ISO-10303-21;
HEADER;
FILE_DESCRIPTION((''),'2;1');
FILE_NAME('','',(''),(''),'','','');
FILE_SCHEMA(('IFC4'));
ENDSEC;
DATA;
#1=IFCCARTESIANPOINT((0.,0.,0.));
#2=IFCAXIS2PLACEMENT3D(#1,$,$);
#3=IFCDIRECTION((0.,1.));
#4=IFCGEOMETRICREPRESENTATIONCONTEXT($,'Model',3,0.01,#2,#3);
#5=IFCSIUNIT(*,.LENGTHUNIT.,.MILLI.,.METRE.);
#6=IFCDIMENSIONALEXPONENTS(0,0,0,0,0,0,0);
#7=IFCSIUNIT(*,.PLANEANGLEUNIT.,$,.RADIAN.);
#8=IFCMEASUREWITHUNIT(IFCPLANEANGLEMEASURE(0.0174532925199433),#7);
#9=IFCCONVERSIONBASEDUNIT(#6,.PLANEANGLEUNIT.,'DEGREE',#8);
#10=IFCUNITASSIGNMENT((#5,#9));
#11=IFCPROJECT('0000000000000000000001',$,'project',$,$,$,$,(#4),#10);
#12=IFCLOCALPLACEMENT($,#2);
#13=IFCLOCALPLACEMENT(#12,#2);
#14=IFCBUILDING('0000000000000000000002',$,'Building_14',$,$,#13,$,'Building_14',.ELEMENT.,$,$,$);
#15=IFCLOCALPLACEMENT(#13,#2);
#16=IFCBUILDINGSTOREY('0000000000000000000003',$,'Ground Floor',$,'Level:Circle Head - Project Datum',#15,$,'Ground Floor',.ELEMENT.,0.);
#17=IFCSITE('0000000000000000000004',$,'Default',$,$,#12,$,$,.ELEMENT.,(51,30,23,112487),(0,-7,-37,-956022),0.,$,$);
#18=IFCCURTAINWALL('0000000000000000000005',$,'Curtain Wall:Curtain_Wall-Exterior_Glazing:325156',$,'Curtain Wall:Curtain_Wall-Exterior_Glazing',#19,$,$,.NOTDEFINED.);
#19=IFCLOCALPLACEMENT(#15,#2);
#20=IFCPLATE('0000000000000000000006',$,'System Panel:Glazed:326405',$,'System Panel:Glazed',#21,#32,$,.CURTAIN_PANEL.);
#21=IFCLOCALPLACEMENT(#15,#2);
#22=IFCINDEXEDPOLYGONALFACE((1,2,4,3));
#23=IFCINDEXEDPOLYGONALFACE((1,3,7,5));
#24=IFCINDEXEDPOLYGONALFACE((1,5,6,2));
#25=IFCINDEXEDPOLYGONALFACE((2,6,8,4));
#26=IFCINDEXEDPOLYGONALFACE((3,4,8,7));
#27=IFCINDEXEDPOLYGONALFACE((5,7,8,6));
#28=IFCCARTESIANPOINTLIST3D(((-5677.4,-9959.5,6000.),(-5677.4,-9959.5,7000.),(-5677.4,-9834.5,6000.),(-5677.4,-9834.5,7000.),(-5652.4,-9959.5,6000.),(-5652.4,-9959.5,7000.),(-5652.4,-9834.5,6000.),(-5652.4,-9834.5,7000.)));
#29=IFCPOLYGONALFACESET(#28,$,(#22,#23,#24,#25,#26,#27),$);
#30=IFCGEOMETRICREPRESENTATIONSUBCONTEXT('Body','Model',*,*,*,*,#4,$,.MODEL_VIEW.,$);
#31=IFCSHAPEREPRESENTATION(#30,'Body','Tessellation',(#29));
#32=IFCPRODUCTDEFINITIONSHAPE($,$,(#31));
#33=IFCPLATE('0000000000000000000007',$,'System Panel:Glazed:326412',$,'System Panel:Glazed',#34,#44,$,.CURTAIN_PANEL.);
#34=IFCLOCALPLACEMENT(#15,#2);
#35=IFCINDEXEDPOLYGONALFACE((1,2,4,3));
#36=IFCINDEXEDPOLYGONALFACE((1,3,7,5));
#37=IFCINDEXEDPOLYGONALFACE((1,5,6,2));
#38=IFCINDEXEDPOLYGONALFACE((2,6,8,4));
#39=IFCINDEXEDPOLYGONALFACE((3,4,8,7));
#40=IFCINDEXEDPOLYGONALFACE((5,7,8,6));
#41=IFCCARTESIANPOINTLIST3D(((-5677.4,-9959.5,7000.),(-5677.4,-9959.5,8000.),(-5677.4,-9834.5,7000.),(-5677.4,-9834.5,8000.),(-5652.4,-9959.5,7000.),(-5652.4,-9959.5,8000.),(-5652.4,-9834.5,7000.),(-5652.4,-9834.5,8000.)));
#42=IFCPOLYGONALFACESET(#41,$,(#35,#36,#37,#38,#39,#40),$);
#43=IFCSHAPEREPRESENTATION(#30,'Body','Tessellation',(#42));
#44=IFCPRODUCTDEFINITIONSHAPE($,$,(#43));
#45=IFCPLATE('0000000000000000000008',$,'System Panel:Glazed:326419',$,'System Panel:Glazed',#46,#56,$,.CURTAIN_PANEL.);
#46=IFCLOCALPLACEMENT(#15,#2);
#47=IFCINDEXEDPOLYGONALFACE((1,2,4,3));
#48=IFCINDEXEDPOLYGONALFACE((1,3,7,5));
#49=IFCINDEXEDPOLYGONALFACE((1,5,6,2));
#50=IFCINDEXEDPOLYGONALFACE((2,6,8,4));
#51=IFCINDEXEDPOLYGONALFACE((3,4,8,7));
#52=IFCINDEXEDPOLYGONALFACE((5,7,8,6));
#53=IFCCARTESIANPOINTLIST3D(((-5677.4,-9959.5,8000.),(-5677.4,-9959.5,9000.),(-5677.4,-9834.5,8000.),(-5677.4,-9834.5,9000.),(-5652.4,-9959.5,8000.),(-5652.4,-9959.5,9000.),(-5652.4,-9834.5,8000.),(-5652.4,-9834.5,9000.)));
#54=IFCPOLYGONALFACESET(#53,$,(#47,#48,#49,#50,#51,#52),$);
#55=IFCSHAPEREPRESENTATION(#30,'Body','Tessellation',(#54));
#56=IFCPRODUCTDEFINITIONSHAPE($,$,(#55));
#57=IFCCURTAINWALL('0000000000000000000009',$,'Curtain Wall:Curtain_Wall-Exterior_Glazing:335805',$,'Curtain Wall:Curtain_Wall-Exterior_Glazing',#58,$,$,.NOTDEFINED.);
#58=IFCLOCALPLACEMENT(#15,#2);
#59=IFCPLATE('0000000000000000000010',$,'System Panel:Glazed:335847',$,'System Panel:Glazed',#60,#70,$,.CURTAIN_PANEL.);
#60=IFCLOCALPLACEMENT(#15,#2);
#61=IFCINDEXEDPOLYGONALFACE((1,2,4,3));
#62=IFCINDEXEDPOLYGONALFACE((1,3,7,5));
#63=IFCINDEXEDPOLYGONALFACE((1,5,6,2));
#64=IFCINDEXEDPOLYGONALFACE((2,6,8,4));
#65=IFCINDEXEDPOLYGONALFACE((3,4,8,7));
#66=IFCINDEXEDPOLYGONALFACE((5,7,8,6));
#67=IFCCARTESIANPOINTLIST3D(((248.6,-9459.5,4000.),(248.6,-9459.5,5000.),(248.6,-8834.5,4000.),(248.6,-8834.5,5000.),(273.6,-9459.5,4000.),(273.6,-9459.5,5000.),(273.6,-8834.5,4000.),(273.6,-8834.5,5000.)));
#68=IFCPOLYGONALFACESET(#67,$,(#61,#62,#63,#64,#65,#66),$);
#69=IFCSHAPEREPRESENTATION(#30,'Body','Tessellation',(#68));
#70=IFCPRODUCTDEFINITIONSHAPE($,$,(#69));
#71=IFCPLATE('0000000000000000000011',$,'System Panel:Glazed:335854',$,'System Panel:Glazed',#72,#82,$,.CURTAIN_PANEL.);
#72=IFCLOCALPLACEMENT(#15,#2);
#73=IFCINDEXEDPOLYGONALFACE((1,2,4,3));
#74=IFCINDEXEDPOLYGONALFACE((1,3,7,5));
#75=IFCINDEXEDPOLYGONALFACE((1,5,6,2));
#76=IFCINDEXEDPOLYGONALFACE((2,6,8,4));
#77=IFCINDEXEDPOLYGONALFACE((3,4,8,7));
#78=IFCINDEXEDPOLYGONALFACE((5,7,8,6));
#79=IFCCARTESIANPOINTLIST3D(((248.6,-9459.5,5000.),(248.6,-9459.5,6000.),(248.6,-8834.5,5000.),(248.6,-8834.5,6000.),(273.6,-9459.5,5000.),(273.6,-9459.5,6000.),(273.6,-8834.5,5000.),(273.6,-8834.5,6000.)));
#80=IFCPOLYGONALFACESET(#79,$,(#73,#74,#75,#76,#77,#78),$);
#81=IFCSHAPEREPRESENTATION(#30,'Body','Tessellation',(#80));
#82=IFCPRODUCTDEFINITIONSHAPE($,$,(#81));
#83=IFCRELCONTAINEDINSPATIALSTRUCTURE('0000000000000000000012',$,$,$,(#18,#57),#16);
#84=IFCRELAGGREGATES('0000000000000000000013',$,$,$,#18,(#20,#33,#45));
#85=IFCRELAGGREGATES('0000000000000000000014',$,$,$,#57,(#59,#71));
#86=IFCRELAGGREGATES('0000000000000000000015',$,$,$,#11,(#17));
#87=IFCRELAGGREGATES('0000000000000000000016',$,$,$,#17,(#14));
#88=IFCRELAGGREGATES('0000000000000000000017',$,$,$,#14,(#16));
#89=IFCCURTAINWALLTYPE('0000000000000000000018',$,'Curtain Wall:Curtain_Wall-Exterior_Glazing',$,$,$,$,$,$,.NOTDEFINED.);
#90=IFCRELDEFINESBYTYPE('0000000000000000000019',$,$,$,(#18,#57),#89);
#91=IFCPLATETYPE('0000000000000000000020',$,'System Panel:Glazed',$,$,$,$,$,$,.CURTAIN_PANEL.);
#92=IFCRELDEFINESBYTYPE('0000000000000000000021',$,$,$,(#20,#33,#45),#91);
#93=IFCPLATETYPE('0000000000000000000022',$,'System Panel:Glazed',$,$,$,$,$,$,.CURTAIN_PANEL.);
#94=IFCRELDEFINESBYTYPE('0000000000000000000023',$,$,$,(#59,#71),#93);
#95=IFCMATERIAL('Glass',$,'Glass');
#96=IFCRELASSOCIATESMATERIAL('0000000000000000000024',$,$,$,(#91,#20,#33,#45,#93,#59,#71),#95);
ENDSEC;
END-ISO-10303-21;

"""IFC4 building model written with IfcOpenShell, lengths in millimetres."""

from ifc_helpers import new_model, entity, si_unit, converted_unit, direction, frame, origin, place, context, subcontext, project, spatial, indexed_curve, outline, extrude, source, transform, mapped, material, type_object, type_shapes, element, aggregate, save


model = new_model("IFC4")

# Units and contexts
model_context = context("Model", 3, precision=0.01, world=origin(), true_north=direction((0.0, 1.0)))
body_context = subcontext(model_context, "Body", "Model", "MODEL_VIEW")
ifc_project = project(units=[si_unit("LENGTHUNIT", "METRE", prefix="MILLI"), converted_unit("PLANEANGLEUNIT", "DEGREE", entity("IfcPlaneAngleMeasure", 0.0174532925199433), si_unit("PLANEANGLEUNIT", "RADIAN"), dimensions=[0, 0, 0, 0, 0, 0, 0])], contexts=[model_context])

# Site, building, storey
site_placement = place(None, origin())
site = spatial("IfcSite", under=ifc_project, at=site_placement, Name="Default", CompositionType="ELEMENT", RefLatitude=(51, 30, 23, 112487), RefLongitude=(0, -7, -37, -956022), RefElevation=0.0)
building_placement = place(site_placement, origin())
building = spatial("IfcBuilding", under=site, at=building_placement, Name="Building_14", LongName="Building_14", CompositionType="ELEMENT")
storey_placement = place(building_placement, origin())
storey = spatial("IfcBuildingStorey", under=building, at=storey_placement, Name="Ground Floor", ObjectType="Level:Circle Head - Project Datum", LongName="Ground Floor", CompositionType="ELEMENT", Elevation=0.0)

# Curtain walls, plates
curtain_wall_type = type_object("IfcCurtainWallType", Name="Curtain Wall:Curtain_Wall-Exterior_Glazing", PredefinedType="NOTDEFINED")
curtain_wall_1_placement = place(storey_placement, origin())
curtain_wall_1 = element("IfcCurtainWall", 1, at=curtain_wall_1_placement, inside=storey, type_object=curtain_wall_type, Name="Curtain Wall:Curtain_Wall-Exterior_Glazing:325156", ObjectType="Curtain Wall:Curtain_Wall-Exterior_Glazing", PredefinedType="NOTDEFINED")
ifc_material = material(Name="Glass", Category="Glass")
plate_type_1 = type_object("IfcPlateType", Name="System Panel:Glazed", PredefinedType="CURTAIN_PANEL", material=ifc_material)
shared_shape_1 = source(origin(), body_context, "Body", "SweptSolid", [
    extrude(outline(indexed_curve([(-12.5, -62.5), (12.5, -62.5), (12.5, 62.5), (-12.5, 62.5), (-12.5, -62.5)], self_intersect=False)), frame((0.0, -37.0, 0.0), z_axis=(0.0, 0.0, 1.0), x_axis=(0.0, 1.0, 0.0)), (0.0, 0.0, 1.0), 1000.0),
])
type_shapes(plate_type_1, [shared_shape_1])
plate_1_placement = place(curtain_wall_1_placement, frame((-5701.9, -9897.0, 6000.0), z_axis=(0.0, 0.0, 1.0), x_axis=(0.0, 1.0, 0.0)))
plate_1 = element("IfcPlate", 2, at=plate_1_placement, type_object=plate_type_1, material=ifc_material, Name="System Panel:Glazed:326405", ObjectType="System Panel:Glazed", PredefinedType="CURTAIN_PANEL", context=body_context, shape_type="MappedRepresentation", body=[
    mapped(shared_shape_1, transform((0.0, 0.0, 0.0), scale=1.0)),
])
plate_2_placement = place(curtain_wall_1_placement, frame((-5701.9, -9897.0, 7000.0), z_axis=(0.0, 0.0, 1.0), x_axis=(0.0, 1.0, 0.0)))
plate_2 = element("IfcPlate", 3, at=plate_2_placement, type_object=plate_type_1, material=ifc_material, Name="System Panel:Glazed:326412", ObjectType="System Panel:Glazed", PredefinedType="CURTAIN_PANEL", context=body_context, shape_type="MappedRepresentation", body=[
    mapped(shared_shape_1, transform((0.0, 0.0, 0.0), scale=1.0)),
])
plate_3_placement = place(curtain_wall_1_placement, frame((-5701.9, -9897.0, 8000.0), z_axis=(0.0, 0.0, 1.0), x_axis=(0.0, 1.0, 0.0)))
plate_3 = element("IfcPlate", 4, at=plate_3_placement, type_object=plate_type_1, material=ifc_material, Name="System Panel:Glazed:326419", ObjectType="System Panel:Glazed", PredefinedType="CURTAIN_PANEL", context=body_context, shape_type="MappedRepresentation", body=[
    mapped(shared_shape_1, transform((0.0, 0.0, 0.0), scale=1.0)),
])
aggregate(curtain_wall_1, [plate_1, plate_2, plate_3])
curtain_wall_2_placement = place(storey_placement, origin())
curtain_wall_2 = element("IfcCurtainWall", 5, at=curtain_wall_2_placement, inside=storey, type_object=curtain_wall_type, Name="Curtain Wall:Curtain_Wall-Exterior_Glazing:335805", ObjectType="Curtain Wall:Curtain_Wall-Exterior_Glazing", PredefinedType="NOTDEFINED")
plate_type_2 = type_object("IfcPlateType", Name="System Panel:Glazed", PredefinedType="CURTAIN_PANEL", material=ifc_material)
shared_shape_2 = source(origin(), body_context, "Body", "SweptSolid", [
    extrude(outline(indexed_curve([(-12.5, -312.5), (12.5, -312.5), (12.5, 312.5), (-12.5, 312.5), (-12.5, -312.5)], self_intersect=False)), frame((0.0, -37.0, 0.0), z_axis=(0.0, 0.0, 1.0), x_axis=(0.0, 1.0, 0.0)), (0.0, 0.0, 1.0), 1000.0),
])
type_shapes(plate_type_2, [shared_shape_2])
plate_4_placement = place(curtain_wall_2_placement, frame((298.1, -9147.0, 4000.0), z_axis=(0.0, 0.0, 1.0), x_axis=(0.0, -1.0, 0.0)))
plate_4 = element("IfcPlate", 6, at=plate_4_placement, type_object=plate_type_2, material=ifc_material, Name="System Panel:Glazed:335847", ObjectType="System Panel:Glazed", PredefinedType="CURTAIN_PANEL", context=body_context, shape_type="MappedRepresentation", body=[
    mapped(shared_shape_2, transform((0.0, 0.0, 0.0), scale=1.0)),
])
plate_5_placement = place(curtain_wall_2_placement, frame((298.1, -9147.0, 5000.0), z_axis=(0.0, 0.0, 1.0), x_axis=(0.0, -1.0, 0.0)))
plate_5 = element("IfcPlate", 7, at=plate_5_placement, type_object=plate_type_2, material=ifc_material, Name="System Panel:Glazed:335854", ObjectType="System Panel:Glazed", PredefinedType="CURTAIN_PANEL", context=body_context, shape_type="MappedRepresentation", body=[
    mapped(shared_shape_2, transform((0.0, 0.0, 0.0), scale=1.0)),
])
aggregate(curtain_wall_2, [plate_4, plate_5])

save(model, "model.ifc")
